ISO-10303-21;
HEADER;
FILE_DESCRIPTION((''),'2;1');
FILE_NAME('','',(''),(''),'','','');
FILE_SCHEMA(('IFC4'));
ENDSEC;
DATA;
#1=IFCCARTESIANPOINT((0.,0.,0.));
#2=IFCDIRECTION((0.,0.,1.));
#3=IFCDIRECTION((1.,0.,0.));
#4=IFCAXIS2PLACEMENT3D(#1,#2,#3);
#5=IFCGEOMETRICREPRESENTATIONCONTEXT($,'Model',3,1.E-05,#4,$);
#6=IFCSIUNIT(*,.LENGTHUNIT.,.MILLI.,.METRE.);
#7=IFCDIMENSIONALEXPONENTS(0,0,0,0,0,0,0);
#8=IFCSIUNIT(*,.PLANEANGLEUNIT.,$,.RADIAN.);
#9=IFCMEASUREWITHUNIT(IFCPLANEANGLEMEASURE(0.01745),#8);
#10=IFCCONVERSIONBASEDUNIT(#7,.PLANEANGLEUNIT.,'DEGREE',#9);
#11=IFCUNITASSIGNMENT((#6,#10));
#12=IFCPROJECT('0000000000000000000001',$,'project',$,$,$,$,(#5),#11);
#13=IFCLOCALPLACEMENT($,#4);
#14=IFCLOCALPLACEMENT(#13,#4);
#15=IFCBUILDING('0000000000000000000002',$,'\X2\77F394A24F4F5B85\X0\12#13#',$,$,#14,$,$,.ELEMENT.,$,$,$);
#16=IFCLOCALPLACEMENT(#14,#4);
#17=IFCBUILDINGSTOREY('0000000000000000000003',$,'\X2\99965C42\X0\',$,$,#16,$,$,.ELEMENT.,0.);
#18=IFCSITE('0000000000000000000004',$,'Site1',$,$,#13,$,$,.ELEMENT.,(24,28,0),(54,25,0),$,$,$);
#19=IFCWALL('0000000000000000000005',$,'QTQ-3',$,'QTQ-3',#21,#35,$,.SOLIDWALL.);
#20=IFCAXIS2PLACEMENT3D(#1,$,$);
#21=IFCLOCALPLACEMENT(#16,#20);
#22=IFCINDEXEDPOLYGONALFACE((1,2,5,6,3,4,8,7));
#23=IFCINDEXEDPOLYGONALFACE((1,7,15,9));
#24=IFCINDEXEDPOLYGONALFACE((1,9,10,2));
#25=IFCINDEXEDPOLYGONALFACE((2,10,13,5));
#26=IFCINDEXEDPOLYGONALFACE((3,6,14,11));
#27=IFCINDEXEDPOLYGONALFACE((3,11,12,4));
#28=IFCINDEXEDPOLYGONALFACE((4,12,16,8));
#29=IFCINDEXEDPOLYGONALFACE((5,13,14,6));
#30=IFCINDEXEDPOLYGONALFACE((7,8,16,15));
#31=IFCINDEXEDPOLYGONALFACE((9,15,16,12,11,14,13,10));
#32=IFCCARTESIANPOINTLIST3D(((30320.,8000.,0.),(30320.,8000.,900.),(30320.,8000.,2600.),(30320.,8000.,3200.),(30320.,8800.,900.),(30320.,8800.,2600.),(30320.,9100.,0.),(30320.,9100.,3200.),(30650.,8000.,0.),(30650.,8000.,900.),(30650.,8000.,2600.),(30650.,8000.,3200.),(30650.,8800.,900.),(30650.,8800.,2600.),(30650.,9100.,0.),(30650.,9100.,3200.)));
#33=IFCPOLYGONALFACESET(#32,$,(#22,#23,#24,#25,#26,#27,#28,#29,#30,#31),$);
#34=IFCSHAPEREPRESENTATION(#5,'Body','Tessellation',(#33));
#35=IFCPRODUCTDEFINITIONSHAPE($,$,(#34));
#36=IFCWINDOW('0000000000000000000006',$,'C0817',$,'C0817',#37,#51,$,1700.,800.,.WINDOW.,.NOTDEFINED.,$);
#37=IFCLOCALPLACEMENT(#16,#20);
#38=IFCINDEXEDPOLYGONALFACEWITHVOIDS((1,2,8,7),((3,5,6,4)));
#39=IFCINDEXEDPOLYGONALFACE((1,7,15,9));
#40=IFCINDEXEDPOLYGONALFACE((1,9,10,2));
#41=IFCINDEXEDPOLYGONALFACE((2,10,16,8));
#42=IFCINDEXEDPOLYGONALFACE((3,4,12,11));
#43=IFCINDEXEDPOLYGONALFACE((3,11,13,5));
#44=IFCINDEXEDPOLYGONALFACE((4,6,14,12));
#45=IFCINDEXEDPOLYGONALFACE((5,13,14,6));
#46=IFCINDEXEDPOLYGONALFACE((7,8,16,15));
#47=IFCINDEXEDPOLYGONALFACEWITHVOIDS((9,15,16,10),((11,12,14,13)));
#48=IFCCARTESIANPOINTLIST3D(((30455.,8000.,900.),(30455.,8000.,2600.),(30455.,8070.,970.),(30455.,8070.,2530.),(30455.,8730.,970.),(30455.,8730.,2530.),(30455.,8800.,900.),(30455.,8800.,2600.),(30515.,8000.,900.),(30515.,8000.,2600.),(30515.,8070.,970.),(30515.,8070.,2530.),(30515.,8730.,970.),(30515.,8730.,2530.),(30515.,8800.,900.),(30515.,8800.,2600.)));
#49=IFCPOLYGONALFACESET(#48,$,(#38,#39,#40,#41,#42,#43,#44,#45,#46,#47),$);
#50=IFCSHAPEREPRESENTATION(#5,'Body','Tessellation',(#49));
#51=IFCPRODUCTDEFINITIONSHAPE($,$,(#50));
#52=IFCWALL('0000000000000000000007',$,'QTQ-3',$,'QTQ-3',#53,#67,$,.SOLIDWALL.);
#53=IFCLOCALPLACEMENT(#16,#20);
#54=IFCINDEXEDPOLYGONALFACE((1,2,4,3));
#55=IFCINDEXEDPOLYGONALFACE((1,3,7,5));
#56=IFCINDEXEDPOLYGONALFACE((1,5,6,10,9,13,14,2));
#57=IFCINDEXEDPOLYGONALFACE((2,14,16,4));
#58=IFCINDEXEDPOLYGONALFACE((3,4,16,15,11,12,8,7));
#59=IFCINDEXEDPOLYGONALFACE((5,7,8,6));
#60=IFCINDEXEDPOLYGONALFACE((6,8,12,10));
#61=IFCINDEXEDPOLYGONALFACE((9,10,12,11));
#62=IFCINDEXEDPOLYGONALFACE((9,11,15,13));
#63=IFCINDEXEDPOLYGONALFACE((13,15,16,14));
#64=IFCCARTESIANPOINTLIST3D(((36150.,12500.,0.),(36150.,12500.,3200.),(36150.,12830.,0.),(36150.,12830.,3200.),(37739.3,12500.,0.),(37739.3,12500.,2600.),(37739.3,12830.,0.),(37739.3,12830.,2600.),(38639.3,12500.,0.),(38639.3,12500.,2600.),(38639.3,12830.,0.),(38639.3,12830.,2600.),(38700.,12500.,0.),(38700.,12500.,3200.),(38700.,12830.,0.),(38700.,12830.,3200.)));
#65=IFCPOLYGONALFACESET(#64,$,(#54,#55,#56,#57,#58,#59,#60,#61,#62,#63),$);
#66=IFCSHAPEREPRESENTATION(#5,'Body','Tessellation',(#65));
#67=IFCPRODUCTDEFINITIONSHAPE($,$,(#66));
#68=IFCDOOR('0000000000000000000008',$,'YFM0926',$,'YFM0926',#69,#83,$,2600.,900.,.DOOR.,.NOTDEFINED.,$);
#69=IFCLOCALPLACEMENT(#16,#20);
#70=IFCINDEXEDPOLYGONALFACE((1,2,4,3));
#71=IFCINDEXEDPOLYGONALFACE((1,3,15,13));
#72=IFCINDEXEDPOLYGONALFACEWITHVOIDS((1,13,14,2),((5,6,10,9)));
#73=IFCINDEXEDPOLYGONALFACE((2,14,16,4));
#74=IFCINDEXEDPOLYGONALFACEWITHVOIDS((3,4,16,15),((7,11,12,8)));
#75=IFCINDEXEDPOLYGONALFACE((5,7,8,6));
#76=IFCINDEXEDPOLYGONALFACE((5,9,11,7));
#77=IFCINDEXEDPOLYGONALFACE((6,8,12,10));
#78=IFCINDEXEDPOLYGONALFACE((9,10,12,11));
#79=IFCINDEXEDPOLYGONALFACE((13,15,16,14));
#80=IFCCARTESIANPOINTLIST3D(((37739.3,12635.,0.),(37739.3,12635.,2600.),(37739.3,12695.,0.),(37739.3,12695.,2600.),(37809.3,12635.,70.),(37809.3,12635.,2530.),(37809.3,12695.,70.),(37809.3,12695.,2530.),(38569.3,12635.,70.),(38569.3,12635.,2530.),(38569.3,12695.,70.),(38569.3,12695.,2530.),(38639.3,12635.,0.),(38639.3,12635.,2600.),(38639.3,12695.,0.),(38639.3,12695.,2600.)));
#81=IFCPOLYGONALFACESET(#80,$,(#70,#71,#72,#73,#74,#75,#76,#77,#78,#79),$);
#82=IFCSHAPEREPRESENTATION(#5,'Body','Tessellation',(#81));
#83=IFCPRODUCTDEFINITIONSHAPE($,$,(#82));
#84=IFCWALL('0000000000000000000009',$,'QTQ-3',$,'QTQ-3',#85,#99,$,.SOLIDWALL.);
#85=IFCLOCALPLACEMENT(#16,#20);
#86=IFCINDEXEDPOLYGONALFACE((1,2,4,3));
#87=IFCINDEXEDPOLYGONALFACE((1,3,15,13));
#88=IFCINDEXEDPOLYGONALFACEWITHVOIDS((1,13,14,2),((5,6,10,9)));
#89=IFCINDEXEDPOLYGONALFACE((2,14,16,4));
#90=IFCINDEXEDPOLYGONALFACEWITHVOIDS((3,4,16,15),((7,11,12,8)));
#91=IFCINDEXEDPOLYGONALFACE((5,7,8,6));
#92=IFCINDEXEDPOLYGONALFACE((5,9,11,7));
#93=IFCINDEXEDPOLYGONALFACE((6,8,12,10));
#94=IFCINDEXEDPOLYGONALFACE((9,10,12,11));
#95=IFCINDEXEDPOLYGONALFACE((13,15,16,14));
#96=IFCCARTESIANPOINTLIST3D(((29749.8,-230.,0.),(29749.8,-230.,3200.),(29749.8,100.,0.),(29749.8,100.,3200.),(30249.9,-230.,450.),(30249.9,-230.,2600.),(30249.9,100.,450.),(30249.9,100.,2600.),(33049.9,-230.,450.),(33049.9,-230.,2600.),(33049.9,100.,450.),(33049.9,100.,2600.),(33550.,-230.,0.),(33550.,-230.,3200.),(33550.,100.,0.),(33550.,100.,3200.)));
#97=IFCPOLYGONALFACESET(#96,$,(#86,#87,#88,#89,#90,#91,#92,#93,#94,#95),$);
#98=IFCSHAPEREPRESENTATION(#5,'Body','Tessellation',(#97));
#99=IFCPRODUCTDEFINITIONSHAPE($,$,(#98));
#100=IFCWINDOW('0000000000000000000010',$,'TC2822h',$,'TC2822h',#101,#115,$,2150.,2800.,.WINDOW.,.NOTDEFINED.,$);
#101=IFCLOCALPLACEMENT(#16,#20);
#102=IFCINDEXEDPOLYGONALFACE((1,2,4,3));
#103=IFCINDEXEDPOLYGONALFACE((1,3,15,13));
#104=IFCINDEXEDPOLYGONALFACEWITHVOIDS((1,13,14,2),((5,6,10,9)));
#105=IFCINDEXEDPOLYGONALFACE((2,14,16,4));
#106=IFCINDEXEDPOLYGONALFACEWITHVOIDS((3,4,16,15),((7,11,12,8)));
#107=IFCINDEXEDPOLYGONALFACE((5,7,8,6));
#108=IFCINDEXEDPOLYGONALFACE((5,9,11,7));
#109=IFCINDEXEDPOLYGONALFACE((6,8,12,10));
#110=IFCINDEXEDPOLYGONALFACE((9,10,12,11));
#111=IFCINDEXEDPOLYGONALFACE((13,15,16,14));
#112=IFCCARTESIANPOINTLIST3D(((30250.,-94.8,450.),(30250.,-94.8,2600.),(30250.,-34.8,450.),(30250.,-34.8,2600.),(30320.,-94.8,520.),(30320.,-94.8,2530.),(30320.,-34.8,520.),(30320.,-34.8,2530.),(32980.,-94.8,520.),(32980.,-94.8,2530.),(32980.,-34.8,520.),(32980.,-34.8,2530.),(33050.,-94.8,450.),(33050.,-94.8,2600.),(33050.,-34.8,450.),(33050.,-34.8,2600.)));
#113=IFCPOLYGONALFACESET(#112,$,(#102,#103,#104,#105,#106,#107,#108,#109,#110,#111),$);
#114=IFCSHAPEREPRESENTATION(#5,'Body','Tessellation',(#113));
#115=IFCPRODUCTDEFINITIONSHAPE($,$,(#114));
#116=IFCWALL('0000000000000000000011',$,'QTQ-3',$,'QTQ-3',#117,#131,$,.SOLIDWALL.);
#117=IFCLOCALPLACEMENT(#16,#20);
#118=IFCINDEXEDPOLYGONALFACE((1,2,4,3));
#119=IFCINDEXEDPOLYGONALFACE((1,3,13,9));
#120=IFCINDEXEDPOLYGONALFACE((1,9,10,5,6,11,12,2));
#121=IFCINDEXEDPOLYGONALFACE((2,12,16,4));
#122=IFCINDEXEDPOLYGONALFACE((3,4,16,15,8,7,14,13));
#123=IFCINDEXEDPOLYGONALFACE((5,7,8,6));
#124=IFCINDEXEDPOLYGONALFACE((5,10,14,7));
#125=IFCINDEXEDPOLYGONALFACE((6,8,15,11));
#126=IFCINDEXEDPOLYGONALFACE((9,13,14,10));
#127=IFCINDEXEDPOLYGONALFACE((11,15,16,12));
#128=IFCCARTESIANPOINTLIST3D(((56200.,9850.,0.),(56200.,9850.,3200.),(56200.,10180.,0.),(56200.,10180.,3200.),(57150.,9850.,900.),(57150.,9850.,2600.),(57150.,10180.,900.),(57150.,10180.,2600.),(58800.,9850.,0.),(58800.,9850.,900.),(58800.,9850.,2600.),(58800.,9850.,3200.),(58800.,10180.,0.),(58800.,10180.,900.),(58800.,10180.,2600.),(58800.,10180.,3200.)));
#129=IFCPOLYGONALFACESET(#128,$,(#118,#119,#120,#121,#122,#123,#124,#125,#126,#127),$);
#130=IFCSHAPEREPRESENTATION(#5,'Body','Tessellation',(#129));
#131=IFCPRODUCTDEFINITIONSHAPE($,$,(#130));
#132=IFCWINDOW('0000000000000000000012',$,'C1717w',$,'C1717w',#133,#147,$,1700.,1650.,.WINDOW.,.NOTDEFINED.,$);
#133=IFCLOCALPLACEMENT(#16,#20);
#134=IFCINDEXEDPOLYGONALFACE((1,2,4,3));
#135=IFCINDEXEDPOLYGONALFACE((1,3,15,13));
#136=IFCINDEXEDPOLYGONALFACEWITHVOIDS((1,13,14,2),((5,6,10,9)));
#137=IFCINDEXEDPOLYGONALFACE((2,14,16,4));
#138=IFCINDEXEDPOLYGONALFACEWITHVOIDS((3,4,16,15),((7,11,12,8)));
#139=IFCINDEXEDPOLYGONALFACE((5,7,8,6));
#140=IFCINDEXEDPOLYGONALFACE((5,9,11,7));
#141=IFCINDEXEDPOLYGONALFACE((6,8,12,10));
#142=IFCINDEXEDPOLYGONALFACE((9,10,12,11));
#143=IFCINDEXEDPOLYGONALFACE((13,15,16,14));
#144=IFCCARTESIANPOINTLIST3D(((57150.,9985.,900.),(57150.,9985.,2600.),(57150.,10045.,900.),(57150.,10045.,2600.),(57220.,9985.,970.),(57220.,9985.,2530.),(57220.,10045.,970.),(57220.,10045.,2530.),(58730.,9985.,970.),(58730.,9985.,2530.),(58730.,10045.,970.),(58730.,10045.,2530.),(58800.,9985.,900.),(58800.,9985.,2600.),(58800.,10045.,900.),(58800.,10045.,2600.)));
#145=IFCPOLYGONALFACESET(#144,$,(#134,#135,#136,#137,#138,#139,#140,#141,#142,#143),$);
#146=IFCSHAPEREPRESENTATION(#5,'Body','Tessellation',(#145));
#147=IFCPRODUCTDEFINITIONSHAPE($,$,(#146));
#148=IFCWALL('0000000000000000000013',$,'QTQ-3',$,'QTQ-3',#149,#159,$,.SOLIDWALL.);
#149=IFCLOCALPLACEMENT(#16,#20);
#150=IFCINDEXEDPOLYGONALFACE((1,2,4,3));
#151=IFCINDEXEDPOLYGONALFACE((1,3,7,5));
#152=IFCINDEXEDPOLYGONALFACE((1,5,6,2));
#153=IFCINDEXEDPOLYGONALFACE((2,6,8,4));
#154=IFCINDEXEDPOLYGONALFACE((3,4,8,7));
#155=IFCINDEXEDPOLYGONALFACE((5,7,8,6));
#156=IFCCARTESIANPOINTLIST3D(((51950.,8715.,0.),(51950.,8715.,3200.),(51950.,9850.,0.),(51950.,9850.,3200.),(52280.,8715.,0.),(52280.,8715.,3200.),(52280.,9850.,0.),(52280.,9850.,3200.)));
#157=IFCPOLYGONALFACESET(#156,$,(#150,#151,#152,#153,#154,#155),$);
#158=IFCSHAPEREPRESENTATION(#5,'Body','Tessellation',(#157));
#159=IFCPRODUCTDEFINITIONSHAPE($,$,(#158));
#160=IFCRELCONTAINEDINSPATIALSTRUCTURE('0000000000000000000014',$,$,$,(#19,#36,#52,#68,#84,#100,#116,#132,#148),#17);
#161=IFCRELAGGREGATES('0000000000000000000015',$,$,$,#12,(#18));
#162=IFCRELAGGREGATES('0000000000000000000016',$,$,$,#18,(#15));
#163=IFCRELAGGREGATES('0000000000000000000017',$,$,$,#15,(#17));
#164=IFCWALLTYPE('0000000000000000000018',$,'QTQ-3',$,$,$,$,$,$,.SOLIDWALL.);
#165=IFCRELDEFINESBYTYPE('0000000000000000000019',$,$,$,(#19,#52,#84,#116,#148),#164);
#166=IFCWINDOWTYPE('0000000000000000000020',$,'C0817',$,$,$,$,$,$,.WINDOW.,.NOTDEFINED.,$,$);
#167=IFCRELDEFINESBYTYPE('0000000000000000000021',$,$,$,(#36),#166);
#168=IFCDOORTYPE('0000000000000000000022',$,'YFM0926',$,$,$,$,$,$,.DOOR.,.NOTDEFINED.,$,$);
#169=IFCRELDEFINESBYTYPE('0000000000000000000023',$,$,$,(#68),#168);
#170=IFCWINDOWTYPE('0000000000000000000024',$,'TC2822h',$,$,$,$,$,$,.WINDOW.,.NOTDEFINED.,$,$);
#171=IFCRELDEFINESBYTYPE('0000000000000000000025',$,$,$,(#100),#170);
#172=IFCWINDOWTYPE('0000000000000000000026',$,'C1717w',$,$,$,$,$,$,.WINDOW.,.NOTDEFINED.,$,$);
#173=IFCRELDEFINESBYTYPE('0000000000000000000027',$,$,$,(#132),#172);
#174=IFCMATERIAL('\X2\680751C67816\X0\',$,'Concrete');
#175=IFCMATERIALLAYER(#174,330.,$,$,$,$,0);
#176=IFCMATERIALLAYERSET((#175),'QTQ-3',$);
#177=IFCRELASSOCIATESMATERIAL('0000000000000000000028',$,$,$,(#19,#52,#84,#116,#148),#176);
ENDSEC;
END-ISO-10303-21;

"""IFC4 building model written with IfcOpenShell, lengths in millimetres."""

from ifc_helpers import new_model, entity, si_unit, converted_unit, frame, origin_with_axes, place, context, project, spatial, polyline, outline, extrude, material, layer, layer_set, type_object, element, fill, save


model = new_model("IFC4")

# Units and contexts
model_context = context("Model", 3, precision=1e-05, world=origin_with_axes())
ifc_project = project(units=[si_unit("LENGTHUNIT", "METRE", prefix="MILLI"), converted_unit("PLANEANGLEUNIT", "DEGREE", entity("IfcPlaneAngleMeasure", 0.01745), si_unit("PLANEANGLEUNIT", "RADIAN"), dimensions=[0, 0, 0, 0, 0, 0, 0])], contexts=[model_context])

# Site, building, storey
site_placement = place(None, origin_with_axes())
site = spatial("IfcSite", under=ifc_project, at=site_placement, Name="Site1", CompositionType="ELEMENT", RefLatitude=(24, 28, 0), RefLongitude=(54, 25, 0))
building_placement = place(site_placement, origin_with_axes())
building = spatial("IfcBuilding", under=site, at=building_placement, Name="石钢住宅12#13#", CompositionType="ELEMENT")
storey_placement = place(building_placement, origin_with_axes())
storey = spatial("IfcBuildingStorey", under=building, at=storey_placement, Name="首层", CompositionType="ELEMENT", Elevation=0.0)

# Wall, opening, window
ifc_material = material(Name="标准砖", Category="Concrete")
ifc_layer = layer(ifc_material, 330.0, Priority=0)
ifc_layer_set = layer_set([ifc_layer], Name="QTQ-3")
wall_type = type_object("IfcWallType", Name="QTQ-3", PredefinedType="SOLIDWALL")
wall_1_placement = place(storey_placement, origin_with_axes())
wall_1 = element("IfcWall", 1, at=wall_1_placement, inside=storey, type_object=wall_type, material=ifc_layer_set, Name="QTQ-3", ObjectType="QTQ-3", PredefinedType="SOLIDWALL", context=model_context, shape_type="SweptSolid", body=[
    extrude(outline(polyline([(0.0, 0.0), (3200.0, 0.0), (3200.0, 1100.0), (0.0, 1100.0), (0.0, 0.0)])), frame((30650.0, 9100.0, 3200.0), z_axis=(-1.0, 0.0, 0.0), x_axis=(0.0, 0.0, -1.0)), (0.0, 0.0, 1.0), 330.0),
])
opening_1_placement = place(storey_placement, origin_with_axes())
opening_1 = element("IfcOpeningElement", 2, at=opening_1_placement, cuts=wall_1, PredefinedType="OPENING", context=model_context, shape_type="SweptSolid", body=[
    extrude(outline(polyline([(0.0, 0.0), (800.0, 0.0), (800.0, 1700.0), (0.0, 1700.0), (0.0, 0.0)])), frame((31650.0, 8800.0, 900.0), z_axis=(-1.0, 0.0, 0.0), x_axis=(0.0, -1.0, 0.0)), (0.0, 0.0, 1.0), 2330.0),
])
window_type_1 = type_object("IfcWindowType", Name="C0817", PartitioningType="NOTDEFINED", PredefinedType="WINDOW")
window_1_placement = place(storey_placement, origin_with_axes())
window_1 = element("IfcWindow", 3, at=window_1_placement, inside=storey, type_object=window_type_1, Name="C0817", ObjectType="C0817", OverallHeight=1700.0, OverallWidth=800.0, PartitioningType="NOTDEFINED", PredefinedType="WINDOW", context=model_context, shape_type="SweptSolid", body=[
    extrude(outline(polyline([(-400.0, -850.0), (400.0, -850.0), (400.0, 850.0), (-400.0, 850.0), (-400.0, -850.0)]), holes=[polyline([(-330.0, -780.0), (-330.0, 780.0), (330.0, 780.0), (330.0, -780.0), (-330.0, -780.0)])]), frame((30515.0, 8400.0, 1750.0), z_axis=(-1.0, 0.0, 0.0), x_axis=(0.0, -1.0, 0.0)), (0.0, 0.0, 1.0), 60.0),
])
fill(opening_1, window_1)

# Wall, opening, door
wall_2_placement = place(storey_placement, origin_with_axes())
wall_2 = element("IfcWall", 4, at=wall_2_placement, inside=storey, type_object=wall_type, material=ifc_layer_set, Name="QTQ-3", ObjectType="QTQ-3", PredefinedType="SOLIDWALL", context=model_context, shape_type="SweptSolid", body=[
    extrude(outline(polyline([(0.0, 0.0), (3200.0, 0.0), (3200.0, 2550.0), (0.0, 2550.0), (0.0, 0.0)])), frame((38700.0, 12500.0, 3200.0), z_axis=(0.0, 1.0, 0.0), x_axis=(0.0, 0.0, -1.0)), (0.0, 0.0, 1.0), 330.0),
])
opening_2_placement = place(storey_placement, origin_with_axes())
opening_2 = element("IfcOpeningElement", 5, at=opening_2_placement, cuts=wall_2, PredefinedType="OPENING", context=model_context, shape_type="SweptSolid", body=[
    extrude(outline(polyline([(0.0, 0.0), (900.0, 0.0), (900.0, 2600.0), (0.0, 2600.0), (0.0, 0.0)])), frame((38639.3, 11500.0, 0.0), z_axis=(0.0, 1.0, 0.0), x_axis=(-1.0, 0.0, 0.0)), (0.0, 0.0, 1.0), 2330.0),
])
door_type = type_object("IfcDoorType", Name="YFM0926", OperationType="NOTDEFINED", PredefinedType="DOOR")
door_1_placement = place(storey_placement, origin_with_axes())
door_1 = element("IfcDoor", 6, at=door_1_placement, inside=storey, type_object=door_type, Name="YFM0926", ObjectType="YFM0926", OperationType="NOTDEFINED", OverallHeight=2600.0, OverallWidth=900.0, PredefinedType="DOOR", context=model_context, shape_type="SweptSolid", body=[
    extrude(outline(polyline([(-450.0, -1300.0), (450.0, -1300.0), (450.0, 1300.0), (-450.0, 1300.0), (-450.0, -1300.0)]), holes=[polyline([(-380.0, -1230.0), (-380.0, 1230.0), (380.0, 1230.0), (380.0, -1230.0), (-380.0, -1230.0)])]), frame((38189.3, 12635.0, 1300.0), z_axis=(0.0, 1.0, 0.0), x_axis=(-1.0, 0.0, 0.0)), (0.0, 0.0, 1.0), 60.0),
])
fill(opening_2, door_1)

# Walls, openings, windows
wall_3_placement = place(storey_placement, origin_with_axes())
wall_3 = element("IfcWall", 7, at=wall_3_placement, inside=storey, type_object=wall_type, material=ifc_layer_set, Name="QTQ-3", ObjectType="QTQ-3", PredefinedType="SOLIDWALL", context=model_context, shape_type="SweptSolid", body=[
    extrude(outline(polyline([(0.0, 0.0), (3200.0, 0.0), (3200.0, 3800.2), (0.0, 3800.2), (0.0, 0.0)])), frame((33550.0, -230.0, 3200.0), z_axis=(0.0, 1.0, 0.0), x_axis=(0.0, 0.0, -1.0)), (0.0, 0.0, 1.0), 330.0),
])
opening_3_placement = place(storey_placement, origin_with_axes())
opening_3 = element("IfcOpeningElement", 8, at=opening_3_placement, cuts=wall_3, PredefinedType="OPENING", context=model_context, shape_type="SweptSolid", body=[
    extrude(outline(polyline([(0.0, 0.0), (2800.0, 0.0), (2800.0, 2150.0), (0.0, 2150.0), (0.0, 0.0)])), frame((33049.9, -1230.0, 450.0), z_axis=(0.0, 1.0, 0.0), x_axis=(-1.0, 0.0, 0.0)), (0.0, 0.0, 1.0), 2330.0),
])
window_type_2 = type_object("IfcWindowType", Name="TC2822h", PartitioningType="NOTDEFINED", PredefinedType="WINDOW")
window_2_placement = place(storey_placement, origin_with_axes())
window_2 = element("IfcWindow", 9, at=window_2_placement, inside=storey, type_object=window_type_2, Name="TC2822h", ObjectType="TC2822h", OverallHeight=2150.0, OverallWidth=2800.0, PartitioningType="NOTDEFINED", PredefinedType="WINDOW", context=model_context, shape_type="SweptSolid", body=[
    extrude(outline(polyline([(-1400.0, -1075.0), (1400.0, -1075.0), (1400.0, 1075.0), (-1400.0, 1075.0), (-1400.0, -1075.0)]), holes=[polyline([(-1330.0, -1005.0), (-1330.0, 1005.0), (1330.0, 1005.0), (1330.0, -1005.0), (-1330.0, -1005.0)])]), frame((31650.0, -94.8, 1525.0), z_axis=(0.0, 1.0, 0.0), x_axis=(-1.0, 0.0, 0.0)), (0.0, 0.0, 1.0), 60.0),
])
fill(opening_3, window_2)
wall_4_placement = place(storey_placement, origin_with_axes())
wall_4 = element("IfcWall", 10, at=wall_4_placement, inside=storey, type_object=wall_type, material=ifc_layer_set, Name="QTQ-3", ObjectType="QTQ-3", PredefinedType="SOLIDWALL", context=model_context, shape_type="SweptSolid", body=[
    extrude(outline(polyline([(0.0, 0.0), (3200.0, 0.0), (3200.0, 2600.0), (0.0, 2600.0), (0.0, 0.0)])), frame((58800.0, 9850.0, 3200.0), z_axis=(0.0, 1.0, 0.0), x_axis=(0.0, 0.0, -1.0)), (0.0, 0.0, 1.0), 330.0),
])
opening_4_placement = place(storey_placement, origin_with_axes())
opening_4 = element("IfcOpeningElement", 11, at=opening_4_placement, cuts=wall_4, PredefinedType="OPENING", context=model_context, shape_type="SweptSolid", body=[
    extrude(outline(polyline([(0.0, 0.0), (1650.0, 0.0), (1650.0, 1700.0), (0.0, 1700.0), (0.0, 0.0)])), frame((58800.0, 8850.0, 900.0), z_axis=(0.0, 1.0, 0.0), x_axis=(-1.0, 0.0, 0.0)), (0.0, 0.0, 1.0), 2330.0),
])
window_type_3 = type_object("IfcWindowType", Name="C1717w", PartitioningType="NOTDEFINED", PredefinedType="WINDOW")
window_3_placement = place(storey_placement, origin_with_axes())
window_3 = element("IfcWindow", 12, at=window_3_placement, inside=storey, type_object=window_type_3, Name="C1717w", ObjectType="C1717w", OverallHeight=1700.0, OverallWidth=1650.0, PartitioningType="NOTDEFINED", PredefinedType="WINDOW", context=model_context, shape_type="SweptSolid", body=[
    extrude(outline(polyline([(-825.0, -850.0), (825.0, -850.0), (825.0, 850.0), (-825.0, 850.0), (-825.0, -850.0)]), holes=[polyline([(-755.0, -780.0), (-755.0, 780.0), (755.0, 780.0), (755.0, -780.0), (-755.0, -780.0)])]), frame((57975.0, 9985.0, 1750.0), z_axis=(0.0, 1.0, 0.0), x_axis=(-1.0, 0.0, 0.0)), (0.0, 0.0, 1.0), 60.0),
])
fill(opening_4, window_3)

# Wall
wall_5_placement = place(storey_placement, origin_with_axes())
element("IfcWall", 13, at=wall_5_placement, inside=storey, type_object=wall_type, material=ifc_layer_set, Name="QTQ-3", ObjectType="QTQ-3", PredefinedType="SOLIDWALL", context=model_context, shape_type="SweptSolid", body=[
    extrude(outline(polyline([(0.0, 0.0), (3200.0, 0.0), (3200.0, 1135.0), (0.0, 1135.0), (0.0, 0.0)])), frame((51950.0, 8715.0, 3200.0), z_axis=(1.0, 0.0, 0.0), x_axis=(0.0, 0.0, -1.0)), (0.0, 0.0, 1.0), 330.0),
])

save(model, "model.ifc")
